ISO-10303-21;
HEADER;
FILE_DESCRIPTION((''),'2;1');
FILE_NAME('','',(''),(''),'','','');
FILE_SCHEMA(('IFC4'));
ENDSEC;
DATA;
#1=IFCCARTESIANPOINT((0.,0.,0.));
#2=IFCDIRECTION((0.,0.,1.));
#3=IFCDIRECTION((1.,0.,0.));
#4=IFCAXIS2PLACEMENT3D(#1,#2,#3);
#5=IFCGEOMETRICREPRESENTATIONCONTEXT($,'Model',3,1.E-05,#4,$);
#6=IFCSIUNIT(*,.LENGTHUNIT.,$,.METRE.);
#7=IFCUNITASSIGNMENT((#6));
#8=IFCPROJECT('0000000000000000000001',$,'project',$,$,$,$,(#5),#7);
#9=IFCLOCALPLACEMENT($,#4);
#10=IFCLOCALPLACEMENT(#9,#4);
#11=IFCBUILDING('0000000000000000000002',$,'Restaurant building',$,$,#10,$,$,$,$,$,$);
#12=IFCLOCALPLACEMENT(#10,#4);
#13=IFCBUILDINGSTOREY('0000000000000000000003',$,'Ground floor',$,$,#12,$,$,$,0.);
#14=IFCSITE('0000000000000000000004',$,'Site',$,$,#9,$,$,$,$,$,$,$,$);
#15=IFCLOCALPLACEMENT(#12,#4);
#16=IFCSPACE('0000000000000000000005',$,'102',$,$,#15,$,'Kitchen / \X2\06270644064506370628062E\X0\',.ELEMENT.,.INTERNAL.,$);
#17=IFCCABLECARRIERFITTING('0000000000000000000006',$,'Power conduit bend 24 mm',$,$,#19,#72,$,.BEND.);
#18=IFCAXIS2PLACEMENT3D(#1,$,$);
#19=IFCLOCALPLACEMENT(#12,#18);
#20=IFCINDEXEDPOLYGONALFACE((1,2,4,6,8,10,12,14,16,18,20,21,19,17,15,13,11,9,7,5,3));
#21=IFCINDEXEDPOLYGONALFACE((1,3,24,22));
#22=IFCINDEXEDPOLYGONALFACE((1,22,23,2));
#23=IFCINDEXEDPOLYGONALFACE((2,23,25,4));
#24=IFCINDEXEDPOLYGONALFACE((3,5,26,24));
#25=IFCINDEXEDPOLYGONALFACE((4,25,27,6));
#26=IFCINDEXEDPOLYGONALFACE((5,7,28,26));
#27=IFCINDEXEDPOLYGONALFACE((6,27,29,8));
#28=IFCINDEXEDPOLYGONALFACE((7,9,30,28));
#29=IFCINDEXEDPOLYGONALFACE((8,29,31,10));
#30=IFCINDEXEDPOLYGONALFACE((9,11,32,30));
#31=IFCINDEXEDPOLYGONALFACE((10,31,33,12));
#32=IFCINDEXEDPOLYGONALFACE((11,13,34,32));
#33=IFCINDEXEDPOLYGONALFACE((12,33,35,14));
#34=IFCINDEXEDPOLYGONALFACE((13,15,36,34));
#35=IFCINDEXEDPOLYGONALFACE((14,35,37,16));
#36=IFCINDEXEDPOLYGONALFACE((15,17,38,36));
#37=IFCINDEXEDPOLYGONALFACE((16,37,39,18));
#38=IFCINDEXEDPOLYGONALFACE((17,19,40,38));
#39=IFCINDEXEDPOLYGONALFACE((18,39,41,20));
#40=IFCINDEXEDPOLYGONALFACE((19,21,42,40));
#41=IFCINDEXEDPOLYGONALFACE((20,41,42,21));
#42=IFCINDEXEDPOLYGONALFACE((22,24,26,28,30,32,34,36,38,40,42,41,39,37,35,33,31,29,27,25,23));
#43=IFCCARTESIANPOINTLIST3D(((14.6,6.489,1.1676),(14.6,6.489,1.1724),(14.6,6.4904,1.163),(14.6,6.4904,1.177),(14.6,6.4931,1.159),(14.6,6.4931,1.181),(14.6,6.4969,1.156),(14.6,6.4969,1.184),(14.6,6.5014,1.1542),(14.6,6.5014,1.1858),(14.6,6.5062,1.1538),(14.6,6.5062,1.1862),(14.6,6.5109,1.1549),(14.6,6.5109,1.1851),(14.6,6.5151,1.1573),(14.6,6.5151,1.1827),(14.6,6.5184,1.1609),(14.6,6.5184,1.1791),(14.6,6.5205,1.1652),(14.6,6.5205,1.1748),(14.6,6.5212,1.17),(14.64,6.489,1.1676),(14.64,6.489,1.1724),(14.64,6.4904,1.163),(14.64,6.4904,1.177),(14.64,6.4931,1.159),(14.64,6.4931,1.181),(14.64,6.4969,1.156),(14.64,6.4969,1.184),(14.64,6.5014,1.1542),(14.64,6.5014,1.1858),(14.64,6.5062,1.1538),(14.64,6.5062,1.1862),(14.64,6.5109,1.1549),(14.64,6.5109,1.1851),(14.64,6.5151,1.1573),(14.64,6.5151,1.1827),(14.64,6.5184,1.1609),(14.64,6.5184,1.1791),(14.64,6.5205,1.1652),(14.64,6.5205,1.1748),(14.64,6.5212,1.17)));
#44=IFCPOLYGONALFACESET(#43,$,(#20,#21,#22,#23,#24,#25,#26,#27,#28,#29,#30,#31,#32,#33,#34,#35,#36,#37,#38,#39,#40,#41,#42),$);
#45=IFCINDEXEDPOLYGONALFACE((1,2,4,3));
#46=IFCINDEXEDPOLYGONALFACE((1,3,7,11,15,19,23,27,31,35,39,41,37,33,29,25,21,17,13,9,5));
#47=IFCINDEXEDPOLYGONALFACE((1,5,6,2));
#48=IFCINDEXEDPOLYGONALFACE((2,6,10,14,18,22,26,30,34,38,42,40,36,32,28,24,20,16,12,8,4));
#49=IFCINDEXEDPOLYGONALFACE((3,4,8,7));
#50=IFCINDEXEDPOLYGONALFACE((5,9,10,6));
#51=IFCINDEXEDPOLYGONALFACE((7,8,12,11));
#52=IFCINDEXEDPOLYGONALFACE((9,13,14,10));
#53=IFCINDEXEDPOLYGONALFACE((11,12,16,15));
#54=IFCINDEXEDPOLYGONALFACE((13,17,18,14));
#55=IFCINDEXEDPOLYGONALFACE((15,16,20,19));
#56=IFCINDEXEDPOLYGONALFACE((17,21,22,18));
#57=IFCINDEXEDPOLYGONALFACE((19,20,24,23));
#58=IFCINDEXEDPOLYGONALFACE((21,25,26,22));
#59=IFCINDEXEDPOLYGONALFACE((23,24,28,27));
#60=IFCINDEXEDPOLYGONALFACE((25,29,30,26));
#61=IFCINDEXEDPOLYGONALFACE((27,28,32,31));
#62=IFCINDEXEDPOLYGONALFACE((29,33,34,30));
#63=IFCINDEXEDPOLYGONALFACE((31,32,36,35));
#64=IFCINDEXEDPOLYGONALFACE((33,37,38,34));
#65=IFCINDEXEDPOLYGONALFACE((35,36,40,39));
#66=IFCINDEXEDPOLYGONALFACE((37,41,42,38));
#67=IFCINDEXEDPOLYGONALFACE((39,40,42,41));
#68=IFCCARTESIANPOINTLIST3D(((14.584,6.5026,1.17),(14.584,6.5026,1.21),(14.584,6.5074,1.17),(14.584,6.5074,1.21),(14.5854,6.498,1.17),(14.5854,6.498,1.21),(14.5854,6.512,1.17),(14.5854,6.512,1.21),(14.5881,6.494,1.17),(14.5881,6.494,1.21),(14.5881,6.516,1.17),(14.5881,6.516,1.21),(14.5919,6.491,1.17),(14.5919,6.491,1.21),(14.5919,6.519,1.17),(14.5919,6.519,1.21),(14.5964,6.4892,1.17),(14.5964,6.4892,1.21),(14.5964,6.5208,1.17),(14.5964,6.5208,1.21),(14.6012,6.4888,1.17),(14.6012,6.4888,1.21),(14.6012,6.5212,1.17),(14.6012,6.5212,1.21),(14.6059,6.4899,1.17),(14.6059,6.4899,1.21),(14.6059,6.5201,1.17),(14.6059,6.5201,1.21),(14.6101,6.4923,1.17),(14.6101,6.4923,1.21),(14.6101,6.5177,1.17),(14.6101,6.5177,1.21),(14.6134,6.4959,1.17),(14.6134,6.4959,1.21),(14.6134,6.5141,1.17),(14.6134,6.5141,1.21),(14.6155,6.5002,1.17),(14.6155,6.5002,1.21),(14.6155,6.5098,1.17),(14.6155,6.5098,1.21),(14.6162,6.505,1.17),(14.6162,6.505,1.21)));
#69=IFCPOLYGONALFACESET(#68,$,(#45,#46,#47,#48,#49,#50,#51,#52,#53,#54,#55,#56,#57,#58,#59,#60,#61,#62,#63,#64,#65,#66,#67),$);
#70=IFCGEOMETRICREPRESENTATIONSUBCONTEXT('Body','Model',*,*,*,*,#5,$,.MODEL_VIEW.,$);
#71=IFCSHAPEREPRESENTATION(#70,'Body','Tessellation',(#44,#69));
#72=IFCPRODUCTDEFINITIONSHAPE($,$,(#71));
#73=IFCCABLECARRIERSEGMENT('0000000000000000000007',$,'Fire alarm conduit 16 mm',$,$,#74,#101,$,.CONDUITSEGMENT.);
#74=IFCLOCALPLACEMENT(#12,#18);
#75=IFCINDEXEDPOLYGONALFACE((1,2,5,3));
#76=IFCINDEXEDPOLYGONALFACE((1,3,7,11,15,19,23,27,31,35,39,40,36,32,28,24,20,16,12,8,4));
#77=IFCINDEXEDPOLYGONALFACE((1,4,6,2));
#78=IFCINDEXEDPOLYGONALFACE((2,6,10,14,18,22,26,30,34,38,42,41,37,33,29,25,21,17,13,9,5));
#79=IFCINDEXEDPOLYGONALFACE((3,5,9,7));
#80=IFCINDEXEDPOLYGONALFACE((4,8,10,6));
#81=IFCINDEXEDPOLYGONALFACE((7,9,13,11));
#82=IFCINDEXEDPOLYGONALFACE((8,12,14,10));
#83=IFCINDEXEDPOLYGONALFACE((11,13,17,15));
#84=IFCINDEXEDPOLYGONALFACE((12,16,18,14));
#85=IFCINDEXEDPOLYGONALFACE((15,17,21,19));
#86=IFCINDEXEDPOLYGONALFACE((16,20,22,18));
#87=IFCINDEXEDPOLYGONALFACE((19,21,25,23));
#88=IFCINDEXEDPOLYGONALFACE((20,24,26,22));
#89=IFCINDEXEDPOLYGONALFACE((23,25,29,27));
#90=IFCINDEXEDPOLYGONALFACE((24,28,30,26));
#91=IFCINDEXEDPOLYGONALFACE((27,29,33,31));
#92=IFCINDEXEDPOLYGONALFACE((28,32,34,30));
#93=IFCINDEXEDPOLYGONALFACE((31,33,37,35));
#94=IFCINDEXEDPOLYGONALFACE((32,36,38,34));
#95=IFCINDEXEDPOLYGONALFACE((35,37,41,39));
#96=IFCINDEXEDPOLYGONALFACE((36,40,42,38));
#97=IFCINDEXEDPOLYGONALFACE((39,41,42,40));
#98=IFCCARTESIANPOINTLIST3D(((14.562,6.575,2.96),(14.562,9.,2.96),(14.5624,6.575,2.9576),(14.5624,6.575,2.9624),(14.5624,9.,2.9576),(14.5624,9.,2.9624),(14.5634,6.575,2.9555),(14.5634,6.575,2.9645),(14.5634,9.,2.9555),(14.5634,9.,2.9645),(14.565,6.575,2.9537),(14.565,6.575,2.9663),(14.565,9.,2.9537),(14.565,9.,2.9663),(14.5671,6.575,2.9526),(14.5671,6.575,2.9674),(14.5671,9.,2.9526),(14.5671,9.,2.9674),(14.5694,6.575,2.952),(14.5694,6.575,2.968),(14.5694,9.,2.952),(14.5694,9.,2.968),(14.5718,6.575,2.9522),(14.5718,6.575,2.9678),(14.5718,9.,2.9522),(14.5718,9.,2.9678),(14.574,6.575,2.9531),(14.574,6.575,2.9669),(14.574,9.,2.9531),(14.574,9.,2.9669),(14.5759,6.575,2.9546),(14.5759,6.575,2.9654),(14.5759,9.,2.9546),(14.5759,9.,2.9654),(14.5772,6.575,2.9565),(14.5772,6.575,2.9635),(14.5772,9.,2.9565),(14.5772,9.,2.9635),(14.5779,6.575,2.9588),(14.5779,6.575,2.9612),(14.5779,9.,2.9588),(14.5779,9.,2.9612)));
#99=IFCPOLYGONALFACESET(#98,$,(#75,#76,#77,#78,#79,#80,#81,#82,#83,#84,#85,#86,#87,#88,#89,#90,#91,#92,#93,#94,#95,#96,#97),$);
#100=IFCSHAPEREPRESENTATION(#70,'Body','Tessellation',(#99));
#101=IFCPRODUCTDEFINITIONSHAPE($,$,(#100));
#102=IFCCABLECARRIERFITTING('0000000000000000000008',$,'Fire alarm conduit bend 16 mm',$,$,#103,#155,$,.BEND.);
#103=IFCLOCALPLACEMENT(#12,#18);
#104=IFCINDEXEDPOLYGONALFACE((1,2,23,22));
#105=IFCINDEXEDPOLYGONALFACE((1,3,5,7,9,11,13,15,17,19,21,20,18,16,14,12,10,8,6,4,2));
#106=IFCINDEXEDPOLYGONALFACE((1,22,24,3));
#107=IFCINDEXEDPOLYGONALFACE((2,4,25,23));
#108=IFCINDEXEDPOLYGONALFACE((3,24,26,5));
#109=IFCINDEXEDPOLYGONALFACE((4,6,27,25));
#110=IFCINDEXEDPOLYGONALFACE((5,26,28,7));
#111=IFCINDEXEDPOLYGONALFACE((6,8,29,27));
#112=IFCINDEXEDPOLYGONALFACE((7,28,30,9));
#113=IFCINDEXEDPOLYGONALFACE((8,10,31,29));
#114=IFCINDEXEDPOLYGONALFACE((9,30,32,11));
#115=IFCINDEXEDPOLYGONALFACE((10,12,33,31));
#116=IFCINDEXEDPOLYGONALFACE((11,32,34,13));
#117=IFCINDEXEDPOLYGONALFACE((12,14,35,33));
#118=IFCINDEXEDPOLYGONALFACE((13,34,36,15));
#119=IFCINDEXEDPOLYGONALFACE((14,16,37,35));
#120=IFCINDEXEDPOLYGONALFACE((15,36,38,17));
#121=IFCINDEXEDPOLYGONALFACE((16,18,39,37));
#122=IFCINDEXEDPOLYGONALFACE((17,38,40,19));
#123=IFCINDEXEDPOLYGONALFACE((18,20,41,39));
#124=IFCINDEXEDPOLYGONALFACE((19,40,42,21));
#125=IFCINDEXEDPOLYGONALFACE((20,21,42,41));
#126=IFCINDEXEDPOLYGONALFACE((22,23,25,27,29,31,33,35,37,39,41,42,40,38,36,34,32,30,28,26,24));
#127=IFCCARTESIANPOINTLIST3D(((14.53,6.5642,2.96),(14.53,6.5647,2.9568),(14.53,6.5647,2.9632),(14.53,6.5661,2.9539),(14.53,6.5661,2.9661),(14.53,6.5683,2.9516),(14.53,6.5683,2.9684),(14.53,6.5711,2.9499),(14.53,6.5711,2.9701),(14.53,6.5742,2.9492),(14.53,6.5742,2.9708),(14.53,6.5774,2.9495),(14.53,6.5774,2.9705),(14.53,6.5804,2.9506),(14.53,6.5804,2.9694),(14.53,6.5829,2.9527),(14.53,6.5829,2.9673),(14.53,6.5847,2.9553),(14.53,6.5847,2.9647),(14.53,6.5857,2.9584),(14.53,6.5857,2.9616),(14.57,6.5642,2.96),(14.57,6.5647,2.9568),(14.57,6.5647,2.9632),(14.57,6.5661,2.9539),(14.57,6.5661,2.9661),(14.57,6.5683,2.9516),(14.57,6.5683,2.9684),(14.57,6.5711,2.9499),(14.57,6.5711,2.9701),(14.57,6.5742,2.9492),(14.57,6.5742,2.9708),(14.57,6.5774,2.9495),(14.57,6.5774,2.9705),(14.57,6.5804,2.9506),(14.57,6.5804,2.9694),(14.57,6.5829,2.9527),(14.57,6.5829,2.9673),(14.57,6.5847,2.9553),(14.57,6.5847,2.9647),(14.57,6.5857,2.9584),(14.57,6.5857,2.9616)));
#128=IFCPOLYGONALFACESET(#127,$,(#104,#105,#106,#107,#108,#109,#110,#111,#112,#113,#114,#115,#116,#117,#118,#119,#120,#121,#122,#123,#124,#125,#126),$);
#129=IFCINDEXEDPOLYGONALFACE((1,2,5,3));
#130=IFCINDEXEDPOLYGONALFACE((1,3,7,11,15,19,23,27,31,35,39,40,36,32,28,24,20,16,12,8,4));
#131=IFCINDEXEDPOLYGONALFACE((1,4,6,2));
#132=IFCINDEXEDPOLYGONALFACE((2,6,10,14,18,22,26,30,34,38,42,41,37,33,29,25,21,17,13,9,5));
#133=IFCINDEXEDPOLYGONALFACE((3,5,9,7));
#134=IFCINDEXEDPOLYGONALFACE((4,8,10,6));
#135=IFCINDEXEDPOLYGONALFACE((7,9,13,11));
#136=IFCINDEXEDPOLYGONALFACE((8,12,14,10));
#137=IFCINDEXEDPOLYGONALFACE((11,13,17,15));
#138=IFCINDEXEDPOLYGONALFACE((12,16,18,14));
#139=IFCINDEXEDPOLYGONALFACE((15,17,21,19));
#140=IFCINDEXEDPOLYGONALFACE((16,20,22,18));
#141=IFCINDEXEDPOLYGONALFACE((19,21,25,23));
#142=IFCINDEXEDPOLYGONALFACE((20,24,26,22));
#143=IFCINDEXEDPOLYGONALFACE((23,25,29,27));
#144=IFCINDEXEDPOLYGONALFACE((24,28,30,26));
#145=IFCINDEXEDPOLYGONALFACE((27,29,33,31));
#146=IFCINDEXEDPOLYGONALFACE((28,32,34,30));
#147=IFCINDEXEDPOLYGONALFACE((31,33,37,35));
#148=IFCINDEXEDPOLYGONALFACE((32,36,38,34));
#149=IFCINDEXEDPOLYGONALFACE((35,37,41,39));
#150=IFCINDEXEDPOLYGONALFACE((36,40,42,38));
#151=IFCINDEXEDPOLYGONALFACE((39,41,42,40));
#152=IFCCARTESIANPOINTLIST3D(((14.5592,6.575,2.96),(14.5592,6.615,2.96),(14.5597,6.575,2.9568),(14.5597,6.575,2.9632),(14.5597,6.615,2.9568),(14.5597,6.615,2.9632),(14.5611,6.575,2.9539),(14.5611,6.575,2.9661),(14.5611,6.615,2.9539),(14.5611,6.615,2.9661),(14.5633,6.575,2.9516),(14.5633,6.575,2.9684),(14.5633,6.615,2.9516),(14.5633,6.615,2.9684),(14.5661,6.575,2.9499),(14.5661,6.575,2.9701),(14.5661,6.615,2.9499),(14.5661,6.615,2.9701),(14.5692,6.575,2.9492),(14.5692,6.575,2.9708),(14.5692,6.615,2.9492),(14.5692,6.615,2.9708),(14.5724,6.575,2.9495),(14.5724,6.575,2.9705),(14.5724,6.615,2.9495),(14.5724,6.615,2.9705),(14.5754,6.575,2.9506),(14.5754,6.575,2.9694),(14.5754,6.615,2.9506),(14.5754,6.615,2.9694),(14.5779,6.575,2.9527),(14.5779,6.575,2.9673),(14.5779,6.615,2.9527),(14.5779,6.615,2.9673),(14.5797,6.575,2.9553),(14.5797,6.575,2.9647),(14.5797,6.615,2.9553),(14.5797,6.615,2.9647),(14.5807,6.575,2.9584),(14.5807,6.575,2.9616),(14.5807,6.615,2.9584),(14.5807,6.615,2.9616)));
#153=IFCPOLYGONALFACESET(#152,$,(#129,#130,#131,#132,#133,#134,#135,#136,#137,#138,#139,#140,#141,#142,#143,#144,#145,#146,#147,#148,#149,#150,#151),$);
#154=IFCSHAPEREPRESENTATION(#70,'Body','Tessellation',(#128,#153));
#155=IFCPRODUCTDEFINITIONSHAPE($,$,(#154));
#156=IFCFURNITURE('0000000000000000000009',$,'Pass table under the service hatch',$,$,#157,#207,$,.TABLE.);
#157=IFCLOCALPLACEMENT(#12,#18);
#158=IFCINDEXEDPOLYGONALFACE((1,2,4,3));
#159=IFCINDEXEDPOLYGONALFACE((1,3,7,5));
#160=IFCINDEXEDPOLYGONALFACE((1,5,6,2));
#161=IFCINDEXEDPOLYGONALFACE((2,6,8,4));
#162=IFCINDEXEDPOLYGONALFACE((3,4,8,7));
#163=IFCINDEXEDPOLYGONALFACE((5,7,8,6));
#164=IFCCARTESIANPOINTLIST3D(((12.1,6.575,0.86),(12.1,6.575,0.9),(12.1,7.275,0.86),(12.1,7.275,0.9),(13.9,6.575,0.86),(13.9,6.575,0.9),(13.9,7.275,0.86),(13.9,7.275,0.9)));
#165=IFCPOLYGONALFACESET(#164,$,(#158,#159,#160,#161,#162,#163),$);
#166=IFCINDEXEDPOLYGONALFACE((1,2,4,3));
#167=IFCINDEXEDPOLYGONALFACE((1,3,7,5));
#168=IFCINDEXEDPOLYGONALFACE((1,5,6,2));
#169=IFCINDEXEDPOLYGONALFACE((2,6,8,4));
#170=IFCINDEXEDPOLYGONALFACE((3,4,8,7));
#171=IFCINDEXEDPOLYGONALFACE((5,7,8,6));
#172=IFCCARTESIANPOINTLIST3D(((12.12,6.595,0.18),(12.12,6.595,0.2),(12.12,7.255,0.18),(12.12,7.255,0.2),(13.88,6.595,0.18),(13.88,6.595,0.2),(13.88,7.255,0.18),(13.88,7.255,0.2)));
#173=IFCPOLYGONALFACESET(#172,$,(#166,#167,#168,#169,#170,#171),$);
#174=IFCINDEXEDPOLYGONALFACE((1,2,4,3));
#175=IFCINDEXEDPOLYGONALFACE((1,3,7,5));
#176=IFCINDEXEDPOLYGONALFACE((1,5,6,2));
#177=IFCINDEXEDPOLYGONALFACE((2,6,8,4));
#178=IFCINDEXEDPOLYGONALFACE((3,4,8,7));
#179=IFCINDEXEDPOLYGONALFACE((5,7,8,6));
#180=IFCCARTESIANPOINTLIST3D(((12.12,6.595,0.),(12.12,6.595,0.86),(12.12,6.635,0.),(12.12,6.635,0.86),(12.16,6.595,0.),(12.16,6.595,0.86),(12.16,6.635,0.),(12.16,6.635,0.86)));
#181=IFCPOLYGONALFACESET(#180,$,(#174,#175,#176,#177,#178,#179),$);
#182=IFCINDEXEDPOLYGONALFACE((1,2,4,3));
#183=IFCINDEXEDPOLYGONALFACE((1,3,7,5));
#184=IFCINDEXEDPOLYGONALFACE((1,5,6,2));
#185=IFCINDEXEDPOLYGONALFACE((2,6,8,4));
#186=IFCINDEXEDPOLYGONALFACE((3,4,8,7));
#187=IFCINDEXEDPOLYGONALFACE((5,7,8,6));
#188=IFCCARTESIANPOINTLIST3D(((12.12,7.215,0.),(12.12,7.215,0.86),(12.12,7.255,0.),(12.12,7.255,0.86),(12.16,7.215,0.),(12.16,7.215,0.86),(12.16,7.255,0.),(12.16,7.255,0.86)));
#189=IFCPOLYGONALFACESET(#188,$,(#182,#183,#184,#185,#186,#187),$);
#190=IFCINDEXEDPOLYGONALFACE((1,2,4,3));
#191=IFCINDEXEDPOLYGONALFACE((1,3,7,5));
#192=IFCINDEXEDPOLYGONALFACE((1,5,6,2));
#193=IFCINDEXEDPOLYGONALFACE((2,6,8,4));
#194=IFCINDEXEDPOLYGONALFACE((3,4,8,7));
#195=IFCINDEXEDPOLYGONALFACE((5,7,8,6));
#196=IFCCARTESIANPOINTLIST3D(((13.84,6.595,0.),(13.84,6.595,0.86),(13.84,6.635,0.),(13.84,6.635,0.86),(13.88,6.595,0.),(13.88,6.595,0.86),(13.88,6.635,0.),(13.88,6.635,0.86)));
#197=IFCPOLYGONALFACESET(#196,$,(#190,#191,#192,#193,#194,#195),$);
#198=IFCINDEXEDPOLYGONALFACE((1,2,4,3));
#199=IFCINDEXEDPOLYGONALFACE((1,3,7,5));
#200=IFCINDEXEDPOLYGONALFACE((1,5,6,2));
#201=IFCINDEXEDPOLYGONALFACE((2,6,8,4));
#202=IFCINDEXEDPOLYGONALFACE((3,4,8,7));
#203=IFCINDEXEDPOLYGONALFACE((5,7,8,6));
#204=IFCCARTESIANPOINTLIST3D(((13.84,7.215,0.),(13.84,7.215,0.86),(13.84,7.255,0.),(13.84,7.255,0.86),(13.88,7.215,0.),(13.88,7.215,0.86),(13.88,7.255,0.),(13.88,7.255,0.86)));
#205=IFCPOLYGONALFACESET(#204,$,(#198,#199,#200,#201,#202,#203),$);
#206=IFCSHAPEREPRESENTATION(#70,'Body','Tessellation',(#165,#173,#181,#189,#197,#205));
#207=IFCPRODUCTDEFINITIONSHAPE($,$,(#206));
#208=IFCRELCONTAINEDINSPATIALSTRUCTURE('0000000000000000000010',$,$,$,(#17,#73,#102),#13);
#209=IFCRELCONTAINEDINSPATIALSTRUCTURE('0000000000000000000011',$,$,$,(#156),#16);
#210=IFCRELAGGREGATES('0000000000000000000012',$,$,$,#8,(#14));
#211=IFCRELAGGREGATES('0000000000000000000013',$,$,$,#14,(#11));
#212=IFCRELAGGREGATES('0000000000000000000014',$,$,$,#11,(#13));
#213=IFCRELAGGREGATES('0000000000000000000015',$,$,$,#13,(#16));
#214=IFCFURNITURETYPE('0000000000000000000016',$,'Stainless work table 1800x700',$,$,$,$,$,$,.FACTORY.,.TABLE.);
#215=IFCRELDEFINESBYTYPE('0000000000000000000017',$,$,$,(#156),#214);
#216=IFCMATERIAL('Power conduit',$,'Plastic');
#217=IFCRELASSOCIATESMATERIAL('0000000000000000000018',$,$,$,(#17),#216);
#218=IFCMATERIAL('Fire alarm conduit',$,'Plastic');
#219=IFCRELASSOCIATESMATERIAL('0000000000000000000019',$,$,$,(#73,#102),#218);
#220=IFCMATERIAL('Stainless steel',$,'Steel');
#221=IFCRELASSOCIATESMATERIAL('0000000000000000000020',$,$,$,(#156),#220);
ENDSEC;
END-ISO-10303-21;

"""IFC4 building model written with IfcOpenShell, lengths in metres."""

from ifc_helpers import new_model, si_unit, frame, origin, origin_with_axes, origin_2d, place, context, subcontext, project, spatial, rectangle, circle, extrude, source, transform, mapped, material, type_object, type_shapes, element, save


model = new_model("IFC4")

# Units and contexts
model_context = context("Model", 3, precision=1e-05, world=origin_with_axes())
body_context = subcontext(model_context, "Body", "Model", "MODEL_VIEW")
ifc_project = project(units=[si_unit("LENGTHUNIT", "METRE")], contexts=[model_context])

# Site, building, storey
site_placement = place(None, origin_with_axes())
site = spatial("IfcSite", under=ifc_project, at=site_placement, Name="Site")
building_placement = place(site_placement, origin_with_axes())
building = spatial("IfcBuilding", under=site, at=building_placement, Name="Restaurant building")
storey_placement = place(building_placement, origin_with_axes())
storey = spatial("IfcBuildingStorey", under=building, at=storey_placement, Name="Ground floor", Elevation=0.0)

# Shared definitions
space_1_placement = place(storey_placement, origin_with_axes())
space_1 = spatial("IfcSpace", under=storey, at=space_1_placement, Name="102", LongName="Kitchen / المطبخ", CompositionType="ELEMENT", PredefinedType="INTERNAL")

# Shared definitions
ifc_material_1 = material(Name="Power conduit", Category="Plastic")

# Cable carrier fitting
cable_carrier_fitting_1_placement = place(storey_placement, frame((14.6, 6.505, 1.17)))
element("IfcCableCarrierFitting", 1, at=cable_carrier_fitting_1_placement, inside=storey, material=ifc_material_1, Name="Power conduit bend 24 mm", PredefinedType="BEND", context=body_context, shape_type="SweptSolid", body=[
    extrude(circle(Radius=0.0162, at=origin_2d()), frame((0.0, 0.0, 0.0), z_axis=(1.0, 0.0, 0.0), x_axis=(0.0, 1.0, 0.0)), (0.0, 0.0, 1.0), 0.04),
    extrude(circle(Radius=0.0162, at=origin_2d()), origin(), (0.0, 0.0, 1.0), 0.04),
])

# Cable carrier segment
ifc_material_2 = material(Name="Fire alarm conduit", Category="Plastic")
cable_carrier_segment_1_placement = place(storey_placement, frame((14.57, 6.575, 2.96)))
element("IfcCableCarrierSegment", 2, at=cable_carrier_segment_1_placement, inside=storey, material=ifc_material_2, Name="Fire alarm conduit 16 mm", PredefinedType="CONDUITSEGMENT", context=body_context, shape_type="SweptSolid", body=[
    extrude(circle(Radius=0.008, at=origin_2d()), frame((0.0, 0.0, 0.0), z_axis=(0.0, 1.0, 0.0), x_axis=(-1.0, 0.0, 0.0)), (0.0, 0.0, 1.0), 2.425),
])

# Cable carrier fitting
cable_carrier_fitting_2_placement = place(storey_placement, frame((14.57, 6.575, 2.96)))
element("IfcCableCarrierFitting", 3, at=cable_carrier_fitting_2_placement, inside=storey, material=ifc_material_2, Name="Fire alarm conduit bend 16 mm", PredefinedType="BEND", context=body_context, shape_type="SweptSolid", body=[
    extrude(circle(Radius=0.0108, at=origin_2d()), frame((0.0, 0.0, 0.0), z_axis=(-1.0, 0.0, 0.0), x_axis=(0.0, -1.0, 0.0)), (0.0, 0.0, 1.0), 0.04),
    extrude(circle(Radius=0.0108, at=origin_2d()), frame((0.0, 0.0, 0.0), z_axis=(0.0, 1.0, 0.0), x_axis=(-1.0, 0.0, 0.0)), (0.0, 0.0, 1.0), 0.04),
])

# Furniture
ifc_material_3 = material(Name="Stainless steel", Category="Steel")
furniture_type = type_object("IfcFurnitureType", Name="Stainless work table 1800x700", AssemblyPlace="FACTORY", PredefinedType="TABLE")
shared_shape_1 = source(origin(), body_context, "Body", "SweptSolid", [
    extrude(rectangle(XDim=1.8, YDim=0.7, at=origin_2d()), frame((0.0, 0.0, 0.86)), (0.0, 0.0, 1.0), 0.04),
    extrude(rectangle(XDim=1.76, YDim=0.66, at=origin_2d()), frame((0.0, 0.0, 0.18)), (0.0, 0.0, 1.0), 0.02),
    extrude(rectangle(XDim=0.04, YDim=0.04, at=origin_2d()), frame((-0.86, -0.31, 0.0)), (0.0, 0.0, 1.0), 0.86),
    extrude(rectangle(XDim=0.04, YDim=0.04, at=origin_2d()), frame((-0.86, 0.31, 0.0)), (0.0, 0.0, 1.0), 0.86),
    extrude(rectangle(XDim=0.04, YDim=0.04, at=origin_2d()), frame((0.86, -0.31, 0.0)), (0.0, 0.0, 1.0), 0.86),
    extrude(rectangle(XDim=0.04, YDim=0.04, at=origin_2d()), frame((0.86, 0.31, 0.0)), (0.0, 0.0, 1.0), 0.86),
])
type_shapes(furniture_type, [shared_shape_1])
furniture_placement = place(storey_placement, frame((13.0, 6.925, 0.0)))
element("IfcFurniture", 4, at=furniture_placement, inside=space_1, type_object=furniture_type, material=ifc_material_3, Name="Pass table under the service hatch", PredefinedType="TABLE", context=body_context, shape_type="MappedRepresentation", body=[
    mapped(shared_shape_1, transform((0.0, 0.0, 0.0))),
])

save(model, "model.ifc")
